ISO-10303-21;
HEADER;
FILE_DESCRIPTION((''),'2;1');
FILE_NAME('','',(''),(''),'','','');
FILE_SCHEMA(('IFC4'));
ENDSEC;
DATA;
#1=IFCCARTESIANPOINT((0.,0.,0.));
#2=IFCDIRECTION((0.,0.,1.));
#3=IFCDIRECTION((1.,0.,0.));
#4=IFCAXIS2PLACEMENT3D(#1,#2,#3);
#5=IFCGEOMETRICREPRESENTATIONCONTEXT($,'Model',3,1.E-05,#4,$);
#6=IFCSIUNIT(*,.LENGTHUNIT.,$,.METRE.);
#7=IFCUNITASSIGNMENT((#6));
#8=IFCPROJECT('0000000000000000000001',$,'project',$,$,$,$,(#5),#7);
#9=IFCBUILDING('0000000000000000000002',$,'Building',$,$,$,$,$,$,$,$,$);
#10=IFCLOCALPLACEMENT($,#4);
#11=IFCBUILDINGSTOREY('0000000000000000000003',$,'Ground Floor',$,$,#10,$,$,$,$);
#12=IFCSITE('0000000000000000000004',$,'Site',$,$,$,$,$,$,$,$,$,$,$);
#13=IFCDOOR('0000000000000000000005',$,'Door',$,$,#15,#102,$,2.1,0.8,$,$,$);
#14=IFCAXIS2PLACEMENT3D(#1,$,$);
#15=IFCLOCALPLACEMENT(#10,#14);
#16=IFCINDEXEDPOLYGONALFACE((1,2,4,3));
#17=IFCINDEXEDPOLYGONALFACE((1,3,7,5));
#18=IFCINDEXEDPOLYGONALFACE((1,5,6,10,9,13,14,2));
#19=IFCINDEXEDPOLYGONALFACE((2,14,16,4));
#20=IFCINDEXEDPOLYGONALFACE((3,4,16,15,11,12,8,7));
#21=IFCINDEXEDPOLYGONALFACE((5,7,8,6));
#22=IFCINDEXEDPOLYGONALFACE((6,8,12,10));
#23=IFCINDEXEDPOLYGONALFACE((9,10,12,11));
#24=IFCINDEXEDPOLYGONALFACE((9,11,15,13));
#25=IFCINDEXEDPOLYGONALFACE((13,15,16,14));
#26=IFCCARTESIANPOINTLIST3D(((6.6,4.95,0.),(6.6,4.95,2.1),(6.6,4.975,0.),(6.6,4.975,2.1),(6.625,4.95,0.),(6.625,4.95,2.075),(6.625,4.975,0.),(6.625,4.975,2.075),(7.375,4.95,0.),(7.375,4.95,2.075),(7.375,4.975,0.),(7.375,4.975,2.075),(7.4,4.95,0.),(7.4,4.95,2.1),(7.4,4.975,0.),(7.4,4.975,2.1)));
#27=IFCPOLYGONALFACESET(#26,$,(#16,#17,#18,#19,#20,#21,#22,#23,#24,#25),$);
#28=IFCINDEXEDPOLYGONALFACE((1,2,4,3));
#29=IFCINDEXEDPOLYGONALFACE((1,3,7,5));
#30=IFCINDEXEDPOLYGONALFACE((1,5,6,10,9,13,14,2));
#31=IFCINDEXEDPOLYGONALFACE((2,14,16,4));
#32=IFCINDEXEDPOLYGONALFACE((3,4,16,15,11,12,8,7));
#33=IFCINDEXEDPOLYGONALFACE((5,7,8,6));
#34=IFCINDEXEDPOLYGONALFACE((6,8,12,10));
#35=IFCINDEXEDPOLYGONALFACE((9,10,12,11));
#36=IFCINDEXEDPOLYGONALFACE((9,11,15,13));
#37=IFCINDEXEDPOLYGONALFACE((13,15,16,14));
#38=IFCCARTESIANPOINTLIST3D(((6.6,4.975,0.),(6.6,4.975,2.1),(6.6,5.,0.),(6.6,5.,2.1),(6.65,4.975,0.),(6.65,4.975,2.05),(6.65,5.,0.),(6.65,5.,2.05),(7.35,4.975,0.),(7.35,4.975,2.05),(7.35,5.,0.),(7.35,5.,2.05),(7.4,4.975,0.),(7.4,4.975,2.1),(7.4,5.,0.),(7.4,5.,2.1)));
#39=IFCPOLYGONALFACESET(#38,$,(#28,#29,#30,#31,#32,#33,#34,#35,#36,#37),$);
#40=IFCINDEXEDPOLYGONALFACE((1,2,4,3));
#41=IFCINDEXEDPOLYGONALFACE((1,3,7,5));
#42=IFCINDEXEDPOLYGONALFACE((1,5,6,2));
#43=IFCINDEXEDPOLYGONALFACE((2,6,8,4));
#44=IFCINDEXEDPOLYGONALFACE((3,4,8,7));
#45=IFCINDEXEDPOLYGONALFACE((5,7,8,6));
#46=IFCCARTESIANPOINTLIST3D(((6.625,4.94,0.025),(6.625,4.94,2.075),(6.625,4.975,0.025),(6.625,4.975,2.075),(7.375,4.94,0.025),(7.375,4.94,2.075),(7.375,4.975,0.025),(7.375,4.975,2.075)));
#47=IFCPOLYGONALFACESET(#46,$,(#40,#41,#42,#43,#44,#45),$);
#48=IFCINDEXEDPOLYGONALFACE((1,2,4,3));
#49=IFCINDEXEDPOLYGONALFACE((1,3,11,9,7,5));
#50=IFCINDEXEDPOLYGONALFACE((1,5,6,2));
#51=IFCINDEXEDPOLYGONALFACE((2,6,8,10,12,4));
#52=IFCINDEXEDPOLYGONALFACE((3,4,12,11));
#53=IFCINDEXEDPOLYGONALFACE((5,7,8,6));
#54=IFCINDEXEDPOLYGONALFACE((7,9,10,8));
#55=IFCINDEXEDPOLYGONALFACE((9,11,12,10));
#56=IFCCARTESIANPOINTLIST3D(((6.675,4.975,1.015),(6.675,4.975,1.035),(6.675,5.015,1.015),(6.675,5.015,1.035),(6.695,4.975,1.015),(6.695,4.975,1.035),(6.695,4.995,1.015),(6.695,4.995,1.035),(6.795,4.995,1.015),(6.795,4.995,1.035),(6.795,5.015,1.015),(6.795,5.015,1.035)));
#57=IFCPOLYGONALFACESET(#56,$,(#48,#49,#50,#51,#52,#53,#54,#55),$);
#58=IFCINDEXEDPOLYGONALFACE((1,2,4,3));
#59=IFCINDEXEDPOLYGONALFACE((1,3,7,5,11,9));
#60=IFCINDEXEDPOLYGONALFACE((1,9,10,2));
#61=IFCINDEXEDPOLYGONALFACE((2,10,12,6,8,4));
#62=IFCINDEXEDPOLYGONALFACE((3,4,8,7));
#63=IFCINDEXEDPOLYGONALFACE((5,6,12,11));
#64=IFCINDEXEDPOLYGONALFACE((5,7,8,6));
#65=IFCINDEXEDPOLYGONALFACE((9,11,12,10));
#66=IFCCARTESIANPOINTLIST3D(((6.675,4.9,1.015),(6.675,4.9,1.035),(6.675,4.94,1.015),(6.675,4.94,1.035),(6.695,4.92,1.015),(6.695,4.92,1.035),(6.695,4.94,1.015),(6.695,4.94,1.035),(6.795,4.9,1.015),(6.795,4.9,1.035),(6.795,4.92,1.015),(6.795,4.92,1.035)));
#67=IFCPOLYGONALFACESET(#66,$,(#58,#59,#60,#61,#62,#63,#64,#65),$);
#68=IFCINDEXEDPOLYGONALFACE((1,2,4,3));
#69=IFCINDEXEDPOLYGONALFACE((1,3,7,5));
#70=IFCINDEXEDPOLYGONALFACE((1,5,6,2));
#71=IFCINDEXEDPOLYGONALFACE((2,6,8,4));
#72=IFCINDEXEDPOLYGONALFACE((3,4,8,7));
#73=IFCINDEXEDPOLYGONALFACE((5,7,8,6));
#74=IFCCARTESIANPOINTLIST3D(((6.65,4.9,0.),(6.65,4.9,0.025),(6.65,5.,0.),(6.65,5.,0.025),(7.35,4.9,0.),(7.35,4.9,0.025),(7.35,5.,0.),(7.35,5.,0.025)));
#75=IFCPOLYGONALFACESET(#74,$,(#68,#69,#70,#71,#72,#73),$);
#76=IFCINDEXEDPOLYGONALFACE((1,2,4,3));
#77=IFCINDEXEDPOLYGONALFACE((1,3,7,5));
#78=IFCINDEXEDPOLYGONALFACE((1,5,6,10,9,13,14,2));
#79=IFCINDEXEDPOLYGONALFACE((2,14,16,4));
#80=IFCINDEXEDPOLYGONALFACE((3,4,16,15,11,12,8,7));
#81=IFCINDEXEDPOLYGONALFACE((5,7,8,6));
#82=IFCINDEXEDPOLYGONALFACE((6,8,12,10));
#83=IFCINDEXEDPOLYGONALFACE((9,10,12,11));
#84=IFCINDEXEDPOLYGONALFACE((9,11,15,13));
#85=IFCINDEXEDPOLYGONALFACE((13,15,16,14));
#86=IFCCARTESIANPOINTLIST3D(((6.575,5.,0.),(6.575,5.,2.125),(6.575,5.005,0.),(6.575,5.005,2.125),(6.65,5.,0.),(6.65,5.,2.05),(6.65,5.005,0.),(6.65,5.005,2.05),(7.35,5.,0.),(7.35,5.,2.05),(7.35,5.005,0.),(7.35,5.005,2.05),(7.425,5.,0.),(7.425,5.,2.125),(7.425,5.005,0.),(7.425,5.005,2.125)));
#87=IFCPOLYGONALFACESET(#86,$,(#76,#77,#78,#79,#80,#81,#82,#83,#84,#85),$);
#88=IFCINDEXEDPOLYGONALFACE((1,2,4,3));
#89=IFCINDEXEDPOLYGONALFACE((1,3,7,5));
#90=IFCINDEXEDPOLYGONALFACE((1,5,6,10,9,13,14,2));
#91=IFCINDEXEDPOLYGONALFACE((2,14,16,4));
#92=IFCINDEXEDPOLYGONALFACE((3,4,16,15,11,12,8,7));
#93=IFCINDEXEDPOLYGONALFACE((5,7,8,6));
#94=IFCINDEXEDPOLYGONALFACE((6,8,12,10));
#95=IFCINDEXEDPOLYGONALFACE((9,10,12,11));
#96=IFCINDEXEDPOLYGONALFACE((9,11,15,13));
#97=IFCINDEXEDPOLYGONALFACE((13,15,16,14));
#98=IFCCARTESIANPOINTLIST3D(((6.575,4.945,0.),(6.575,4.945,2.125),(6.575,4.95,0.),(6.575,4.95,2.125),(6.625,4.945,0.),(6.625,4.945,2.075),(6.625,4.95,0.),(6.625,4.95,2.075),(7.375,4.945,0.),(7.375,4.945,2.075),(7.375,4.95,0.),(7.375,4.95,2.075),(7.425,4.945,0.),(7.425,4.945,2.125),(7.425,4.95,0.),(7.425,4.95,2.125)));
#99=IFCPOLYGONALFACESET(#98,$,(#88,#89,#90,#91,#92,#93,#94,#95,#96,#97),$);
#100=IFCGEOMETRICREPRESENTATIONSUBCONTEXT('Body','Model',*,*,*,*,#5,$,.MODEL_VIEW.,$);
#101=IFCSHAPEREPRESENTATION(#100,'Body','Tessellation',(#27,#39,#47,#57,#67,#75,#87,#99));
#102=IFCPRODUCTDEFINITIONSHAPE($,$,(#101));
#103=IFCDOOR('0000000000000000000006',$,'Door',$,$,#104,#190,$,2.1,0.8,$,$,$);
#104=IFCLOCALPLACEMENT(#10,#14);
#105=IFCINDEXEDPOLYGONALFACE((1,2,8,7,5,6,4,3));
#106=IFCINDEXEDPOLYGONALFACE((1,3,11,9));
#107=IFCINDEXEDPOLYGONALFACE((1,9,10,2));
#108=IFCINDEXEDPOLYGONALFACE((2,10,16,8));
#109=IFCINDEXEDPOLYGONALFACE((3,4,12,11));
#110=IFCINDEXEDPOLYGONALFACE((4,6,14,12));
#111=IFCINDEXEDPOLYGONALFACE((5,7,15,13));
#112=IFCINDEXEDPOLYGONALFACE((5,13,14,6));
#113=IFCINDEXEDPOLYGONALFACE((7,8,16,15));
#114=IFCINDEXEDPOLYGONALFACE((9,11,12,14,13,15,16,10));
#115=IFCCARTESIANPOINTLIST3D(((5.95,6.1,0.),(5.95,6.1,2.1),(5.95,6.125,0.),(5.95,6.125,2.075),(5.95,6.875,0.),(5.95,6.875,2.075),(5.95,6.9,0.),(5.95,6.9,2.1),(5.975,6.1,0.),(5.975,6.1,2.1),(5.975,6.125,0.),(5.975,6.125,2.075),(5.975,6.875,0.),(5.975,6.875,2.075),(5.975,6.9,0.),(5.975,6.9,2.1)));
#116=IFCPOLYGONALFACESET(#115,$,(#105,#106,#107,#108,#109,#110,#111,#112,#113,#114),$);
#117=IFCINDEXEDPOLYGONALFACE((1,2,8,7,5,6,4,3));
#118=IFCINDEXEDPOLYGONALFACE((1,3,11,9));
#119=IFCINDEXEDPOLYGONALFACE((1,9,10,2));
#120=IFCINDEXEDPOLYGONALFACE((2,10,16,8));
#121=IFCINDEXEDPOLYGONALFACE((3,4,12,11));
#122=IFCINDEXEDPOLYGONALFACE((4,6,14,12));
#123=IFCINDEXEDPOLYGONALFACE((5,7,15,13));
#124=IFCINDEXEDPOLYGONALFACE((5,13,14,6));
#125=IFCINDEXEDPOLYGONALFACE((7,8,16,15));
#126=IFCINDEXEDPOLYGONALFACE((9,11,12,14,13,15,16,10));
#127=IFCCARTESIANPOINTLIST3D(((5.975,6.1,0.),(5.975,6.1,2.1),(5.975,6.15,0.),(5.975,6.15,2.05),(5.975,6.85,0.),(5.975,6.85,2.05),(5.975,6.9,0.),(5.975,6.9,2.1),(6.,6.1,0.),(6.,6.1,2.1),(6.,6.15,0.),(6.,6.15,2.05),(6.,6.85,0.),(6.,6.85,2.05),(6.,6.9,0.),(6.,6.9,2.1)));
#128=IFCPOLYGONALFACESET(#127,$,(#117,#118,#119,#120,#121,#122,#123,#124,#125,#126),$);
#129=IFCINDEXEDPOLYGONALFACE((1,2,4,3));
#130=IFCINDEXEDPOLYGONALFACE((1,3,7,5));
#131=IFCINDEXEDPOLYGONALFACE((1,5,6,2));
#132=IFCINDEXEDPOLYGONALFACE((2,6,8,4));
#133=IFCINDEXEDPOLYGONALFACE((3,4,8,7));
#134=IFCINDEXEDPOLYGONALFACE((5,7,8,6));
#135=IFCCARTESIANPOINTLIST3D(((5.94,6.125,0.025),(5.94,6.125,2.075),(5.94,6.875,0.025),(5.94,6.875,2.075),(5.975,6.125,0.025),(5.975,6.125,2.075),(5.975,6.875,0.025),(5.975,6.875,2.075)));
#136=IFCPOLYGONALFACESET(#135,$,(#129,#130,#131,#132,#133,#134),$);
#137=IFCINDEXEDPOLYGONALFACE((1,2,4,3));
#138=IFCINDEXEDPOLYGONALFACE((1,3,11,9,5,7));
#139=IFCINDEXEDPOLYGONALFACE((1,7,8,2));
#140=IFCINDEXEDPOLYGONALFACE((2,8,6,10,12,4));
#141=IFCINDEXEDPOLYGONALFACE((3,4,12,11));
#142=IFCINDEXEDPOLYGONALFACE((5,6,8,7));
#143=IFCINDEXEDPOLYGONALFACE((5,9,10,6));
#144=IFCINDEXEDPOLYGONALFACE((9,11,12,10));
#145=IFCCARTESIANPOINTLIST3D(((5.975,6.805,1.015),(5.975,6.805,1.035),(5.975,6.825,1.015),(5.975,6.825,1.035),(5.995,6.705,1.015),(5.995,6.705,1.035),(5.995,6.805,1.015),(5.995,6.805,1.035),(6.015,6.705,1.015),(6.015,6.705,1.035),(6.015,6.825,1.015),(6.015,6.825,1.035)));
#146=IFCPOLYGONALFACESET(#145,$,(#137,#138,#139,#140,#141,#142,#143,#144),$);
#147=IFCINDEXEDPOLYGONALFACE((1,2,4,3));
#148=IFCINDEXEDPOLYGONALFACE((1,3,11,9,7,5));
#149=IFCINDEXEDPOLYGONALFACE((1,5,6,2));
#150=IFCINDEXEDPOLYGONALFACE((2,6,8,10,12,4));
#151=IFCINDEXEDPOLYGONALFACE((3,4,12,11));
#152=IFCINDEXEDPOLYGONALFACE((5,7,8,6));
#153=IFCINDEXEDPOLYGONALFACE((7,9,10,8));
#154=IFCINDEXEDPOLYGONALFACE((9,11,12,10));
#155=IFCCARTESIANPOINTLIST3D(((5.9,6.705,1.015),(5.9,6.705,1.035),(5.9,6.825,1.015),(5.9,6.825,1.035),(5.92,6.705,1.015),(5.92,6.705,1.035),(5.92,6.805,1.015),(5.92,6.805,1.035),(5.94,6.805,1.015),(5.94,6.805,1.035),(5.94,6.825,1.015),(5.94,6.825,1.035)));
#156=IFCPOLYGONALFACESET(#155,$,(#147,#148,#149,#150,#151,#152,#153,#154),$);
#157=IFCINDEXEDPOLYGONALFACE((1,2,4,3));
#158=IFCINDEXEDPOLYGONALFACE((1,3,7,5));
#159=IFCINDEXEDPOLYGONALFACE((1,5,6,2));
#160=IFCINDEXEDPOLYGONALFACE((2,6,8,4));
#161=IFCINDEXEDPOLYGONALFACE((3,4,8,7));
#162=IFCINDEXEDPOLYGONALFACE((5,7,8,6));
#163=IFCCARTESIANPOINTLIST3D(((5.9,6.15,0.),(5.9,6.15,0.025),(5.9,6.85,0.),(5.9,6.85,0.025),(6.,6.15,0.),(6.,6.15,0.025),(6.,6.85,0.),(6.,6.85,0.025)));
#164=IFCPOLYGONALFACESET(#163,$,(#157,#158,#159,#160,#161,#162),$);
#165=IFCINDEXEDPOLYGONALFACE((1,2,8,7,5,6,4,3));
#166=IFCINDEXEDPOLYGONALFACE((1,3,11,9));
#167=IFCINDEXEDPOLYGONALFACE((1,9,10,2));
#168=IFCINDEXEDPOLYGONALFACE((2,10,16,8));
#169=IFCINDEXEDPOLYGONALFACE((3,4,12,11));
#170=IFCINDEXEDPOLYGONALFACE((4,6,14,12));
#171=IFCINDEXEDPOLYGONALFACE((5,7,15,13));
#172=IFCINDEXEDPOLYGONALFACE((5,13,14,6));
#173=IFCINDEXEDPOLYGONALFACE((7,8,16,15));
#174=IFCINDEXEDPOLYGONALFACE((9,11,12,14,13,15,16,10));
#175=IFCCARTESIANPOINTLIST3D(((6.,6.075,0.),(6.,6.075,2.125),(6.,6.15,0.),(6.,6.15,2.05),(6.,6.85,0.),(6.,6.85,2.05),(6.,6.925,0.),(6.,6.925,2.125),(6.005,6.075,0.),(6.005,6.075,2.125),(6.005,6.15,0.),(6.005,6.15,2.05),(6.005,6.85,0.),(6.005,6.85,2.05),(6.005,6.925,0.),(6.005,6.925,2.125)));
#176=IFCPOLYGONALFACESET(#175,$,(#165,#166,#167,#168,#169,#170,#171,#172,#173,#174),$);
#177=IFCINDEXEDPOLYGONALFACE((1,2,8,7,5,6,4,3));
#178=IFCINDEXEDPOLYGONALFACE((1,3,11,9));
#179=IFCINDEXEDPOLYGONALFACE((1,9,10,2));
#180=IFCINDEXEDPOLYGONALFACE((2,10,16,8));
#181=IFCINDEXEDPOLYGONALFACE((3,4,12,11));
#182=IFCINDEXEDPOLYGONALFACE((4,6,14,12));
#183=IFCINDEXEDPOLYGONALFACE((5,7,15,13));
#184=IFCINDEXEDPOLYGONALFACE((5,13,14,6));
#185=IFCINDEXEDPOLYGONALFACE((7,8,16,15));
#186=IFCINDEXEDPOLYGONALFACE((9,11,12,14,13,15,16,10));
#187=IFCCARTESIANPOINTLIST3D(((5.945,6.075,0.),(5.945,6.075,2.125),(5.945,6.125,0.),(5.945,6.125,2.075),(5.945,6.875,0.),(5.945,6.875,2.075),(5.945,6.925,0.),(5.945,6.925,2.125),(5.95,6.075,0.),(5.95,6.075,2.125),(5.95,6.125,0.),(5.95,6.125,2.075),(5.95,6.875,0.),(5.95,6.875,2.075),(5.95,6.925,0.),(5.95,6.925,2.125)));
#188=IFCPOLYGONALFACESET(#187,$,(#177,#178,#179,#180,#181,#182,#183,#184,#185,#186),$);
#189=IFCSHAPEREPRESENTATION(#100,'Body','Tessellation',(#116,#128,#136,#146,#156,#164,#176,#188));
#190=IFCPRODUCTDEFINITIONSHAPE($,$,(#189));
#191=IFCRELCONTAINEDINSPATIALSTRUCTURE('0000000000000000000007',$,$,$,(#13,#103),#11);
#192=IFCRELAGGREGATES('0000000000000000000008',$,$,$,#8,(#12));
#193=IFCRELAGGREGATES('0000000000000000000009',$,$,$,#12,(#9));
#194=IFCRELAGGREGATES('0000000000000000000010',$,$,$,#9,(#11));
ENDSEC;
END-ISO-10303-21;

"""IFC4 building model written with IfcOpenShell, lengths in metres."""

from ifc_helpers import new_model, si_unit, frame, origin_with_axes, place, context, subcontext, project, spatial, line, indexed_curve, outline, extrude, element, save


model = new_model("IFC4")

# Units and contexts
model_context = context("Model", 3, precision=1e-05, world=origin_with_axes())
body_context = subcontext(model_context, "Body", "Model", "MODEL_VIEW")
ifc_project = project(units=[si_unit("LENGTHUNIT", "METRE")], contexts=[model_context])

# Site, building, storey
site = spatial("IfcSite", under=ifc_project, Name="Site")
building = spatial("IfcBuilding", under=site, Name="Building")
storey_placement = place(None, origin_with_axes())
storey = spatial("IfcBuildingStorey", under=building, at=storey_placement, Name="Ground Floor")

# Doors
door_1_placement = place(storey_placement, frame((7.4, 5.0, 0.0), z_axis=(0.0, 0.0, 1.0), x_axis=(-1.0, 0.0, 0.0)))
element("IfcDoor", 1, at=door_1_placement, inside=storey, Name="Door", OverallHeight=2.1, OverallWidth=0.8, context=body_context, shape_type="SweptSolid", body=[
    extrude(outline(indexed_curve([(0.0, 0.0), (0.0, 2.1), (0.8, 2.1), (0.8, 0.0), (0.775, 0.0), (0.775, 2.075), (0.025, 2.075), (0.025, 0.0)], segments=[line(1, 2, 3, 4, 5, 6, 7, 8, 1)])), frame((0.0, 0.025, 0.0), z_axis=(0.0, -1.0, 0.0), x_axis=(1.0, 0.0, 0.0)), (0.0, 0.0, -1.0), 0.025),
    extrude(outline(indexed_curve([(0.0, 0.0), (0.0, 2.1), (0.8, 2.1), (0.8, 0.0), (0.75, 0.0), (0.75, 2.05), (0.05, 2.05), (0.05, 0.0)], segments=[line(1, 2, 3, 4, 5, 6, 7, 8, 1)])), frame((0.0, 0.0, 0.0), z_axis=(0.0, -1.0, 0.0), x_axis=(1.0, 0.0, 0.0)), (0.0, 0.0, -1.0), 0.025),
    extrude(outline(indexed_curve([(0.0, 0.0), (0.75, 0.0), (0.75, 0.035), (0.0, 0.035)], segments=[line(1, 2, 3, 4, 1)])), frame((0.025, 0.025, 0.025), z_axis=(0.0, 0.0, 1.0), x_axis=(1.0, 0.0, 0.0)), (0.0, 0.0, 1.0), 2.05),
    extrude(outline(indexed_curve([(0.0, 0.0), (0.0, -0.04), (-0.12, -0.04), (-0.12, -0.02), (-0.02, -0.02), (-0.02, 0.0)], segments=[line(1, 2, 3, 4, 5, 6, 1)])), frame((0.725, 0.025, 1.015), z_axis=(0.0, 0.0, 1.0), x_axis=(1.0, 0.0, 0.0)), (0.0, 0.0, 1.0), 0.02),
    extrude(outline(indexed_curve([(0.0, 0.0), (0.0, 0.04), (-0.12, 0.04), (-0.12, 0.02), (-0.02, 0.02), (-0.02, 0.0)], segments=[line(1, 2, 3, 4, 5, 6, 1)])), frame((0.725, 0.06, 1.015), z_axis=(0.0, 0.0, 1.0), x_axis=(1.0, 0.0, 0.0)), (0.0, 0.0, 1.0), 0.02),
    extrude(outline(indexed_curve([(0.0, 0.0), (0.7, 0.0), (0.7, 0.1), (0.0, 0.1)], segments=[line(1, 2, 3, 4, 1)])), frame((0.05, 0.0, 0.0), z_axis=(0.0, 0.0, 1.0), x_axis=(1.0, 0.0, 0.0)), (0.0, 0.0, 1.0), 0.025),
    extrude(outline(indexed_curve([(0.0, 0.0), (0.0, 2.125), (0.85, 2.125), (0.85, 0.0), (0.775, 0.0), (0.775, 2.05), (0.075, 2.05), (0.075, 0.0)], segments=[line(1, 2, 3, 4, 5, 6, 7, 8, 1)])), frame((-0.025, -0.005, 0.0), z_axis=(0.0, -1.0, 0.0), x_axis=(1.0, 0.0, 0.0)), (0.0, 0.0, -1.0), 0.005),
    extrude(outline(indexed_curve([(0.0, 0.0), (0.0, 2.125), (0.85, 2.125), (0.85, 0.0), (0.8, 0.0), (0.8, 2.075), (0.05, 2.075), (0.05, 0.0)], segments=[line(1, 2, 3, 4, 5, 6, 7, 8, 1)])), frame((-0.025, 0.05, 0.0), z_axis=(0.0, -1.0, 0.0), x_axis=(1.0, 0.0, 0.0)), (0.0, 0.0, -1.0), 0.005),
])
door_2_placement = place(storey_placement, frame((6.0, 6.1, 0.0), z_axis=(0.0, 0.0, 1.0), x_axis=(0.0, 1.0, 0.0)))
element("IfcDoor", 2, at=door_2_placement, inside=storey, Name="Door", OverallHeight=2.1, OverallWidth=0.8, context=body_context, shape_type="SweptSolid", body=[
    extrude(outline(indexed_curve([(0.0, 0.0), (0.0, 2.1), (0.8, 2.1), (0.8, 0.0), (0.775, 0.0), (0.775, 2.075), (0.025, 2.075), (0.025, 0.0)], segments=[line(1, 2, 3, 4, 5, 6, 7, 8, 1)])), frame((0.0, 0.025, 0.0), z_axis=(0.0, -1.0, 0.0), x_axis=(1.0, 0.0, 0.0)), (0.0, 0.0, -1.0), 0.025),
    extrude(outline(indexed_curve([(0.0, 0.0), (0.0, 2.1), (0.8, 2.1), (0.8, 0.0), (0.75, 0.0), (0.75, 2.05), (0.05, 2.05), (0.05, 0.0)], segments=[line(1, 2, 3, 4, 5, 6, 7, 8, 1)])), frame((0.0, 0.0, 0.0), z_axis=(0.0, -1.0, 0.0), x_axis=(1.0, 0.0, 0.0)), (0.0, 0.0, -1.0), 0.025),
    extrude(outline(indexed_curve([(0.0, 0.0), (0.75, 0.0), (0.75, 0.035), (0.0, 0.035)], segments=[line(1, 2, 3, 4, 1)])), frame((0.025, 0.025, 0.025), z_axis=(0.0, 0.0, 1.0), x_axis=(1.0, 0.0, 0.0)), (0.0, 0.0, 1.0), 2.05),
    extrude(outline(indexed_curve([(0.0, 0.0), (0.0, -0.04), (-0.12, -0.04), (-0.12, -0.02), (-0.02, -0.02), (-0.02, 0.0)], segments=[line(1, 2, 3, 4, 5, 6, 1)])), frame((0.725, 0.025, 1.015), z_axis=(0.0, 0.0, 1.0), x_axis=(1.0, 0.0, 0.0)), (0.0, 0.0, 1.0), 0.02),
    extrude(outline(indexed_curve([(0.0, 0.0), (0.0, 0.04), (-0.12, 0.04), (-0.12, 0.02), (-0.02, 0.02), (-0.02, 0.0)], segments=[line(1, 2, 3, 4, 5, 6, 1)])), frame((0.725, 0.06, 1.015), z_axis=(0.0, 0.0, 1.0), x_axis=(1.0, 0.0, 0.0)), (0.0, 0.0, 1.0), 0.02),
    extrude(outline(indexed_curve([(0.0, 0.0), (0.7, 0.0), (0.7, 0.1), (0.0, 0.1)], segments=[line(1, 2, 3, 4, 1)])), frame((0.05, 0.0, 0.0), z_axis=(0.0, 0.0, 1.0), x_axis=(1.0, 0.0, 0.0)), (0.0, 0.0, 1.0), 0.025),
    extrude(outline(indexed_curve([(0.0, 0.0), (0.0, 2.125), (0.85, 2.125), (0.85, 0.0), (0.775, 0.0), (0.775, 2.05), (0.075, 2.05), (0.075, 0.0)], segments=[line(1, 2, 3, 4, 5, 6, 7, 8, 1)])), frame((-0.025, -0.005, 0.0), z_axis=(0.0, -1.0, 0.0), x_axis=(1.0, 0.0, 0.0)), (0.0, 0.0, -1.0), 0.005),
    extrude(outline(indexed_curve([(0.0, 0.0), (0.0, 2.125), (0.85, 2.125), (0.85, 0.0), (0.8, 0.0), (0.8, 2.075), (0.05, 2.075), (0.05, 0.0)], segments=[line(1, 2, 3, 4, 5, 6, 7, 8, 1)])), frame((-0.025, 0.05, 0.0), z_axis=(0.0, -1.0, 0.0), x_axis=(1.0, 0.0, 0.0)), (0.0, 0.0, -1.0), 0.005),
])

save(model, "model.ifc")
